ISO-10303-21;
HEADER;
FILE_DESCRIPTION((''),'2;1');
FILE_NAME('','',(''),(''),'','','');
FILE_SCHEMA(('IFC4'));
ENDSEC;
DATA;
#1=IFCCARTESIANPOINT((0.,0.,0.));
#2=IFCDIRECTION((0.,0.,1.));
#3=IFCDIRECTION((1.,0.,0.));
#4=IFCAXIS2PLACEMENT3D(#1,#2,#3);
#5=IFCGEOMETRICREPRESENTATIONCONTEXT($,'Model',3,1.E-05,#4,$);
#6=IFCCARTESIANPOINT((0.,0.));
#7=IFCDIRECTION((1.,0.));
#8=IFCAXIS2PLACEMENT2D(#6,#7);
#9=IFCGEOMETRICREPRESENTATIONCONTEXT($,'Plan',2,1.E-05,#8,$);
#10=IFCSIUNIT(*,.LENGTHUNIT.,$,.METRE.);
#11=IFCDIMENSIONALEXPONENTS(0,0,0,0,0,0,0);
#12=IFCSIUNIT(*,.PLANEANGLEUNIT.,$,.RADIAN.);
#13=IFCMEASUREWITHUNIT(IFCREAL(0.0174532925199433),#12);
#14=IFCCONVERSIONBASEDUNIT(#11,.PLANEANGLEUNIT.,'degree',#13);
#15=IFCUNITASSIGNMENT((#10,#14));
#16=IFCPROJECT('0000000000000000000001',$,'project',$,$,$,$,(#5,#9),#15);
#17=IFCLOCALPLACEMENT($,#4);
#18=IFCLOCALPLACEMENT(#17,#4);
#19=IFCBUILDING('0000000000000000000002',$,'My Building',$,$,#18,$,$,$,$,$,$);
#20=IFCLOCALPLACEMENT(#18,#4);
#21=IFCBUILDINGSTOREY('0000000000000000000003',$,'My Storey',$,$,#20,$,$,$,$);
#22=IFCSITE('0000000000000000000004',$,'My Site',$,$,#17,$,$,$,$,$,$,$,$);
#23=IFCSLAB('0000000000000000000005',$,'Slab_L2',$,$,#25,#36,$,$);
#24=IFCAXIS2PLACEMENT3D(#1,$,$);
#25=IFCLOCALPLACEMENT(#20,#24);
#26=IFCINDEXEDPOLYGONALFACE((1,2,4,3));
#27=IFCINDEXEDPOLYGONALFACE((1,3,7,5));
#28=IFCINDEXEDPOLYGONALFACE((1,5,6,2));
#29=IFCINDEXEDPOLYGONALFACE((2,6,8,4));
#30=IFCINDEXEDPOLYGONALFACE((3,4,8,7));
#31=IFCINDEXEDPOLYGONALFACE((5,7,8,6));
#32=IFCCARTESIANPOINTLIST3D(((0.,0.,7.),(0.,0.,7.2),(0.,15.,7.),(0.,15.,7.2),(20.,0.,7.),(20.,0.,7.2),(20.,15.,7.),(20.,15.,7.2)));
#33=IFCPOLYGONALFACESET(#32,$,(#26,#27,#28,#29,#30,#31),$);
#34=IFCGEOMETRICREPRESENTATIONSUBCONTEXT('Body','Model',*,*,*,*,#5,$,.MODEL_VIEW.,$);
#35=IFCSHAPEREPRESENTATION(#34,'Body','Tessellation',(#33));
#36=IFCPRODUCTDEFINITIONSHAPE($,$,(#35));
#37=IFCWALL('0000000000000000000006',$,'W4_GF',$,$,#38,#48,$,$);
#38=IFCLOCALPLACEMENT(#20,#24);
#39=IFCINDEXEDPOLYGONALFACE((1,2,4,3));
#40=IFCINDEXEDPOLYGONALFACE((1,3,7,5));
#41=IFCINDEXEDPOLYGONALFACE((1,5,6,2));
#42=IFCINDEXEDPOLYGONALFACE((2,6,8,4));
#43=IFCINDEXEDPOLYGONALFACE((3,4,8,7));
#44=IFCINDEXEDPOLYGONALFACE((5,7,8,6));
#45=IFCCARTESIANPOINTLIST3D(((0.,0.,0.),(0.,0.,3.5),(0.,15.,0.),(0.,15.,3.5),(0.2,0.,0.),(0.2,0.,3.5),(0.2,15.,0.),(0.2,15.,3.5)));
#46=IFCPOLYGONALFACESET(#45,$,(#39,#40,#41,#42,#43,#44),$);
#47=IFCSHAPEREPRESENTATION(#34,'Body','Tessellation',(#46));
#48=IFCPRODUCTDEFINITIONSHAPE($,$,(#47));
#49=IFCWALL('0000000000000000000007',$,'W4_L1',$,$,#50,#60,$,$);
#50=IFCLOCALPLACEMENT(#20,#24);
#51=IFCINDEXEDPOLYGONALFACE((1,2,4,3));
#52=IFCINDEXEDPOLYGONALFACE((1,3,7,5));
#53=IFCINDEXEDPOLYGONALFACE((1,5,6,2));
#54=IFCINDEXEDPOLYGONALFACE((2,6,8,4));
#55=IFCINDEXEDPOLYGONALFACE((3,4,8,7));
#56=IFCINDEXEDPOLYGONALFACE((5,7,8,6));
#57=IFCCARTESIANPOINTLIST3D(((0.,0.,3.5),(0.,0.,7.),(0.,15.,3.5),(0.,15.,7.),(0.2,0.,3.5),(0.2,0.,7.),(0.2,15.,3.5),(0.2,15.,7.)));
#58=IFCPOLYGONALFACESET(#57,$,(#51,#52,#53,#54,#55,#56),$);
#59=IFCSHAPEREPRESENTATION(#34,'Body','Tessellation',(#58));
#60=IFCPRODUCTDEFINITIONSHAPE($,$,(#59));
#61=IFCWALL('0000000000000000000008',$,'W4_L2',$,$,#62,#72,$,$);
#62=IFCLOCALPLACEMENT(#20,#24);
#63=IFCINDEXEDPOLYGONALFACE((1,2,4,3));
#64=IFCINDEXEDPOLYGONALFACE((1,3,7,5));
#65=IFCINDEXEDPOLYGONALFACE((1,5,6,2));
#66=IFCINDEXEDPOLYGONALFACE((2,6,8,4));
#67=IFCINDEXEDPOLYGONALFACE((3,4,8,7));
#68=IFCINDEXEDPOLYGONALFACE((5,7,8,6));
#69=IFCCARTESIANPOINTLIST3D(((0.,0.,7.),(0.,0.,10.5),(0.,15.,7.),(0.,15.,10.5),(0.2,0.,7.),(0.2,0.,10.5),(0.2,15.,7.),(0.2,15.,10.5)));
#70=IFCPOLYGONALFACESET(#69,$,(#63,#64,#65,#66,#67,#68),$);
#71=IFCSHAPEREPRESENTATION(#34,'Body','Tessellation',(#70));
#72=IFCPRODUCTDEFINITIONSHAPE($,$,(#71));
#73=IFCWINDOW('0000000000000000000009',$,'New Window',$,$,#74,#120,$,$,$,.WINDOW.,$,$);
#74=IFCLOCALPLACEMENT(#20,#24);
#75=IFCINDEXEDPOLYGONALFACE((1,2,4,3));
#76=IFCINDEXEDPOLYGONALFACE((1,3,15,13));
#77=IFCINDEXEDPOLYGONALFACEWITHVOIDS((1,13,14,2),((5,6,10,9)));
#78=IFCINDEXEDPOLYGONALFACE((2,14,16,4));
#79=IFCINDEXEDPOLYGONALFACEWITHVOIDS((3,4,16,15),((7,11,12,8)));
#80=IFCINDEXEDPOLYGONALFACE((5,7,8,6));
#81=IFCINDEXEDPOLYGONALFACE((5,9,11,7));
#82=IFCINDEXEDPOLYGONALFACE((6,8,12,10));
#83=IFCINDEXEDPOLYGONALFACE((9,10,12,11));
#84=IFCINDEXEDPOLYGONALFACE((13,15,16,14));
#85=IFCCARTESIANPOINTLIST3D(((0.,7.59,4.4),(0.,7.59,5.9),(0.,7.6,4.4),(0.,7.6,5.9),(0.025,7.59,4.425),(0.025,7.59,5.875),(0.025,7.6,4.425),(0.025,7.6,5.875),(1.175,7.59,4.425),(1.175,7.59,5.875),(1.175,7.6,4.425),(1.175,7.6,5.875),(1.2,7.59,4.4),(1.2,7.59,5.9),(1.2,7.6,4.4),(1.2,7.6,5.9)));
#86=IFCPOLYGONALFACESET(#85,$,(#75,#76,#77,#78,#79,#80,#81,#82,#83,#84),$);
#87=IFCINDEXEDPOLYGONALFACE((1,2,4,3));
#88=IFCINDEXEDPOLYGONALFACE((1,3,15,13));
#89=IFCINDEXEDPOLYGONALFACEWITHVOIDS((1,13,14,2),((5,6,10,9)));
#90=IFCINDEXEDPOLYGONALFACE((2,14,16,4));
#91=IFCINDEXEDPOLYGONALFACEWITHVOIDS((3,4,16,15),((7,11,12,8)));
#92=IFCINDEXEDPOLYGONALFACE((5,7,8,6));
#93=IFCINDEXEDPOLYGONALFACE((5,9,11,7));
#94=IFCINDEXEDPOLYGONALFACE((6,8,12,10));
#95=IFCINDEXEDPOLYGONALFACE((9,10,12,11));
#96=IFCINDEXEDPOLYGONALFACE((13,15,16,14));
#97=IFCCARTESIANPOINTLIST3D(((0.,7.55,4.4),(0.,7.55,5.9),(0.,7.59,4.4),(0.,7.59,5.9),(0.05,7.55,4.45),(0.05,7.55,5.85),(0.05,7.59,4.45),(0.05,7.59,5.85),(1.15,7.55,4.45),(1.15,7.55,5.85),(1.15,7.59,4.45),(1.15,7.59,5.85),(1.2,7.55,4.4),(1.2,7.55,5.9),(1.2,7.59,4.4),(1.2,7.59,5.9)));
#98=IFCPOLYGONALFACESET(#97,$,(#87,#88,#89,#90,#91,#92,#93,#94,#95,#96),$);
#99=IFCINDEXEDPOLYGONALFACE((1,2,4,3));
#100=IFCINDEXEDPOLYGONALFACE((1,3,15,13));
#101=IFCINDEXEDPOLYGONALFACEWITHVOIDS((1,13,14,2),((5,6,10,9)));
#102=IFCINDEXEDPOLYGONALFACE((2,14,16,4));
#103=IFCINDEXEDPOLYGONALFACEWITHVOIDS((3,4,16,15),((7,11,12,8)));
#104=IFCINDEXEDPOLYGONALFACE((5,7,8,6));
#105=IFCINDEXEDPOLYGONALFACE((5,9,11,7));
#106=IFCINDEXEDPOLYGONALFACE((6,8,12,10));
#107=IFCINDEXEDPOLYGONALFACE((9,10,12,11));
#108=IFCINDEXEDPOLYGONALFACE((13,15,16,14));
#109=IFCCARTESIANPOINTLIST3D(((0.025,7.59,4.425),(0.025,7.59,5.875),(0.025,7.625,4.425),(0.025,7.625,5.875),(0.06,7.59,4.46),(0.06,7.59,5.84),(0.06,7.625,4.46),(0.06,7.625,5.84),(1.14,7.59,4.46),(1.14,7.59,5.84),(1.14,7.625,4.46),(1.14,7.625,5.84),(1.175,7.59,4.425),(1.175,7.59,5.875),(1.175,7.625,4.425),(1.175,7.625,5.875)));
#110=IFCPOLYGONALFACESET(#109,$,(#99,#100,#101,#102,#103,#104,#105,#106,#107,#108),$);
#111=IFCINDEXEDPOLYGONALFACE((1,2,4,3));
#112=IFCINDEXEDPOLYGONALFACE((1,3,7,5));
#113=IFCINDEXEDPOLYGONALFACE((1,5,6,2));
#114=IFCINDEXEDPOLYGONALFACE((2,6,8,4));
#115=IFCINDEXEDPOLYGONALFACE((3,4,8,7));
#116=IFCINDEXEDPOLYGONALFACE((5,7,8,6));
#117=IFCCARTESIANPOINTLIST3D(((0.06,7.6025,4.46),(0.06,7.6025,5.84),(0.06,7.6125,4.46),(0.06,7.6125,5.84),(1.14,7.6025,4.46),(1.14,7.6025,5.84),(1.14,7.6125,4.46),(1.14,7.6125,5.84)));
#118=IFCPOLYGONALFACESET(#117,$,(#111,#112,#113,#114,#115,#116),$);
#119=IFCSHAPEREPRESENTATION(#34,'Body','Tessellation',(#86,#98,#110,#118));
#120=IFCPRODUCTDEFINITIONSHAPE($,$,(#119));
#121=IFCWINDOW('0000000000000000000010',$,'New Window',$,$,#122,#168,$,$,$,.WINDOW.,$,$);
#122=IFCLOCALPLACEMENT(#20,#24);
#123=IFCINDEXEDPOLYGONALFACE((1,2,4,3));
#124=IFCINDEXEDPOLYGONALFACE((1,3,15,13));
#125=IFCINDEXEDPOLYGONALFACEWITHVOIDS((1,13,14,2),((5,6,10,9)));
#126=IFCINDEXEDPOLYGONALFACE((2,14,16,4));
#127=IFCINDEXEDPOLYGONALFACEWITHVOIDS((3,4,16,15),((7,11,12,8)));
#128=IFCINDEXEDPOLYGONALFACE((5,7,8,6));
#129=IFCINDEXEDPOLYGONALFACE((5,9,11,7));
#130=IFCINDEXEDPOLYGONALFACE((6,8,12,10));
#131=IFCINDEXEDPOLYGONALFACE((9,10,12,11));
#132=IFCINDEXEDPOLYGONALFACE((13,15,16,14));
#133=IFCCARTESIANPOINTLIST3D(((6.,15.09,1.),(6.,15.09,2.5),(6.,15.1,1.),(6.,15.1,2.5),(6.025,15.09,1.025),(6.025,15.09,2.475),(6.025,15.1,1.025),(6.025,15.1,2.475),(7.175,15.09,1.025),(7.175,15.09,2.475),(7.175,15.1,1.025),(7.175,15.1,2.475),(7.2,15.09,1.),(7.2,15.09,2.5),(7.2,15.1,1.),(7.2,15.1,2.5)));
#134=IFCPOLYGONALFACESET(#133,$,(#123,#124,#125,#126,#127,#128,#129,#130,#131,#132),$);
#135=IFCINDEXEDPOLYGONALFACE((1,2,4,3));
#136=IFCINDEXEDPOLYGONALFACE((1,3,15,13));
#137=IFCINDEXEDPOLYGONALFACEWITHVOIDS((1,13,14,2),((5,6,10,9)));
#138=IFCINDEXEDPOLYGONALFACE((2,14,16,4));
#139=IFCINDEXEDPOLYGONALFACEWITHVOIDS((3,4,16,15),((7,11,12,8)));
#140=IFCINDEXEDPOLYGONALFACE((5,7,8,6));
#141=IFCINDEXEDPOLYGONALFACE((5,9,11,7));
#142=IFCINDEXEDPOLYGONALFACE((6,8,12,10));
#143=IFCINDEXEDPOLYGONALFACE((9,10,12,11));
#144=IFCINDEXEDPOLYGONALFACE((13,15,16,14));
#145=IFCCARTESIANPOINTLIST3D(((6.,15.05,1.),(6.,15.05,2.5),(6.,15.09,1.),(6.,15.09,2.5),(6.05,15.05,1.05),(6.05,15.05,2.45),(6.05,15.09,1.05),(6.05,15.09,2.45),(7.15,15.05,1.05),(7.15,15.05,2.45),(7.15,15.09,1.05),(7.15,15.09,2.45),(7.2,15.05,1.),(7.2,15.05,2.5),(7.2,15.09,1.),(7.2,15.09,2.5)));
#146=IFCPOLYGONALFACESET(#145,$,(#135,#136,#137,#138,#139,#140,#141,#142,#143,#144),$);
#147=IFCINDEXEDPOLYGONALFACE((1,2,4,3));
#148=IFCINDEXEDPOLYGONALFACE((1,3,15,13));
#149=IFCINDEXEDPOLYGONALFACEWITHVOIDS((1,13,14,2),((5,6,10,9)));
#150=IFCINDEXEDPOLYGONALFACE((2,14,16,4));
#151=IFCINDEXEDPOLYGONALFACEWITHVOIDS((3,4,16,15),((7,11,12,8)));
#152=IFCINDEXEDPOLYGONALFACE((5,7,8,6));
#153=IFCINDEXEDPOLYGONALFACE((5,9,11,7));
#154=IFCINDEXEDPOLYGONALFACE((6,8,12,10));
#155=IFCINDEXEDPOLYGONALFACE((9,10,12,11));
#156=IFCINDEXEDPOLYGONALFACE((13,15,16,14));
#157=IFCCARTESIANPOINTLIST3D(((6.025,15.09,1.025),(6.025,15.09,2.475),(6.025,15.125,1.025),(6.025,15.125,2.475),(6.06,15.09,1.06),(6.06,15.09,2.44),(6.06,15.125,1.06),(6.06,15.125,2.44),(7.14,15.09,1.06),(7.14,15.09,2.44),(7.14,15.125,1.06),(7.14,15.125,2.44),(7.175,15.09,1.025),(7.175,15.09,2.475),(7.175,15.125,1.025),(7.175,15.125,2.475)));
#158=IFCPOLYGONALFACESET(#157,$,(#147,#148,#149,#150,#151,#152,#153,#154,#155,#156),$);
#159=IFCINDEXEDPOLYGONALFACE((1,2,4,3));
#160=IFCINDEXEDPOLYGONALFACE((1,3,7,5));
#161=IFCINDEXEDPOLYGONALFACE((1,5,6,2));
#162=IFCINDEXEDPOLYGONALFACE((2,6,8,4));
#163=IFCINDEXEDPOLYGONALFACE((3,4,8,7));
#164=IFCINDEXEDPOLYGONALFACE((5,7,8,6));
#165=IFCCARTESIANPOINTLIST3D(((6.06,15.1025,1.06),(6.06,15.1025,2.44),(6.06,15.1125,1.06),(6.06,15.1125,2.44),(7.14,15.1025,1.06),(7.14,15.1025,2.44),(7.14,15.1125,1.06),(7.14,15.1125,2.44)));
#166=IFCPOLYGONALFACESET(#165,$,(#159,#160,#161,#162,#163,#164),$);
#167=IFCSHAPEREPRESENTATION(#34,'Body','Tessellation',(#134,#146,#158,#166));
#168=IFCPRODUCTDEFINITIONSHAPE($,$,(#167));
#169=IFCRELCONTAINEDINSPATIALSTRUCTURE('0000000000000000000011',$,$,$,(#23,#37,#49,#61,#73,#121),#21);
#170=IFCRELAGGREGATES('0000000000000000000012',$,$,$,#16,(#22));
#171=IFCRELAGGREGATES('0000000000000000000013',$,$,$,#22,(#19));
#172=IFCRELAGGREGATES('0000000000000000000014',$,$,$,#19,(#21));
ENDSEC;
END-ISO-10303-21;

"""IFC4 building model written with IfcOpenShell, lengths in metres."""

from ifc_helpers import new_model, entity, si_unit, converted_unit, frame, origin_with_axes, origin_2d_with_axis, place, context, subcontext, project, spatial, line, indexed_curve, outline, extrude, element, save


model = new_model("IFC4")

# Units and contexts
model_context = context("Model", 3, precision=1e-05, world=origin_with_axes())
plan_context = context("Plan", 2, precision=1e-05, world=origin_2d_with_axis())
body_context = subcontext(model_context, "Body", "Model", "MODEL_VIEW")
ifc_project = project(units=[si_unit("LENGTHUNIT", "METRE"), converted_unit("PLANEANGLEUNIT", "degree", entity("IfcReal", 0.0174532925199433), si_unit("PLANEANGLEUNIT", "RADIAN"), dimensions=[0, 0, 0, 0, 0, 0, 0])], contexts=[model_context, plan_context])

# Site, building, storey
site_placement = place(None, origin_with_axes())
site = spatial("IfcSite", under=ifc_project, at=site_placement, Name="My Site")
building_placement = place(site_placement, origin_with_axes())
building = spatial("IfcBuilding", under=site, at=building_placement, Name="My Building")
storey_placement = place(building_placement, origin_with_axes())
storey = spatial("IfcBuildingStorey", under=building, at=storey_placement, Name="My Storey")

# Slab
slab_placement = place(storey_placement, frame((0.0, 0.0, 7.0), z_axis=(0.0, 0.0, 1.0), x_axis=(1.0, 0.0, 0.0)))
element("IfcSlab", 1, at=slab_placement, inside=storey, Name="Slab_L2", context=body_context, shape_type="SweptSolid", body=[
    extrude(outline(indexed_curve([(0.0, 0.0), (20.0, 0.0), (20.0, 15.0), (0.0, 15.0), (0.0, 0.0)])), None, (0.0, 0.0, 1.0), 0.2),
])

# Walls
for number, where, z_axis, x_axis, name in (
    (2, (0.0, 15.0, 0.0), (0.0, 0.0, 1.0), (0.0, -1.0, 0.0), "W4_GF"),
    (3, (0.0, 15.0, 3.5), (0.0, 0.0, 1.0), (0.0, -1.0, 0.0), "W4_L1"),
    (4, (0.0, 15.0, 7.0), (0.0, 0.0, 1.0), (0.0, -1.0, 0.0), "W4_L2"),
):
    element("IfcWall", number, at=place(storey_placement, frame(where, z_axis=z_axis, x_axis=x_axis)), inside=storey, Name=name, context=body_context, shape_type="SweptSolid", body=[
        extrude(outline(indexed_curve([(0.0, 0.0), (0.0, 0.2), (15.0, 0.2), (15.0, 0.0), (0.0, 0.0)], self_intersect=False)), origin_with_axes(), (0.0, 0.0, 1.0), 3.5),
    ])

# Window
window_1_placement = place(storey_placement, frame((0.0, 7.5, 4.4), z_axis=(0.0, 0.0, 1.0), x_axis=(1.0, 0.0, 0.0)))
element("IfcWindow", 5, at=window_1_placement, inside=storey, Name="New Window", PredefinedType="WINDOW", context=body_context, shape_type="SweptSolid", body=[
    extrude(outline(indexed_curve([(0.0, 0.0), (1.2, 0.0), (1.2, 1.5), (0.0, 1.5)], segments=[line(1, 2, 3, 4, 1)]), holes=[indexed_curve([(0.025, 0.025), (1.175, 0.025), (1.175, 1.475), (0.025, 1.475)], segments=[line(1, 2, 3, 4, 1)])]), frame((0.0, 0.09, 0.0), z_axis=(0.0, -1.0, 0.0), x_axis=(1.0, 0.0, 0.0)), (0.0, 0.0, -1.0), 0.01),
    extrude(outline(indexed_curve([(0.0, 0.0), (1.2, 0.0), (1.2, 1.5), (0.0, 1.5)], segments=[line(1, 2, 3, 4, 1)]), holes=[indexed_curve([(0.05, 0.05), (1.15, 0.05), (1.15, 1.45), (0.05, 1.45)], segments=[line(1, 2, 3, 4, 1)])]), frame((0.0, 0.05, 0.0), z_axis=(0.0, -1.0, 0.0), x_axis=(1.0, 0.0, 0.0)), (0.0, 0.0, -1.0), 0.04),
    extrude(outline(indexed_curve([(0.0, 0.0), (1.15, 0.0), (1.15, 1.45), (0.0, 1.45)], segments=[line(1, 2, 3, 4, 1)]), holes=[indexed_curve([(0.035, 0.035), (1.115, 0.035), (1.115, 1.415), (0.035, 1.415)], segments=[line(1, 2, 3, 4, 1)])]), frame((0.025, 0.09, 0.025), z_axis=(0.0, -1.0, 0.0), x_axis=(1.0, 0.0, 0.0)), (0.0, 0.0, -1.0), 0.035),
    extrude(outline(indexed_curve([(0.035, 0.035), (1.115, 0.035), (1.115, 1.415), (0.035, 1.415)], segments=[line(1, 2, 3, 4, 1)])), frame((0.025, 0.1025, 0.025), z_axis=(0.0, -1.0, 0.0), x_axis=(1.0, 0.0, 0.0)), (0.0, 0.0, -1.0), 0.01),
])

# Window
window_2_placement = place(storey_placement, frame((6.0, 15.0, 1.0), z_axis=(0.0, 0.0, 1.0), x_axis=(1.0, 0.0, 0.0)))
element("IfcWindow", 6, at=window_2_placement, inside=storey, Name="New Window", PredefinedType="WINDOW", context=body_context, shape_type="SweptSolid", body=[
    extrude(outline(indexed_curve([(0.0, 0.0), (1.2, 0.0), (1.2, 1.5), (0.0, 1.5)], segments=[line(1, 2, 3, 4, 1)]), holes=[indexed_curve([(0.025, 0.025), (1.175, 0.025), (1.175, 1.475), (0.025, 1.475)], segments=[line(1, 2, 3, 4, 1)])]), frame((0.0, 0.09, 0.0), z_axis=(0.0, -1.0, 0.0), x_axis=(1.0, 0.0, 0.0)), (0.0, 0.0, -1.0), 0.01),
    extrude(outline(indexed_curve([(0.0, 0.0), (1.2, 0.0), (1.2, 1.5), (0.0, 1.5)], segments=[line(1, 2, 3, 4, 1)]), holes=[indexed_curve([(0.05, 0.05), (1.15, 0.05), (1.15, 1.45), (0.05, 1.45)], segments=[line(1, 2, 3, 4, 1)])]), frame((0.0, 0.05, 0.0), z_axis=(0.0, -1.0, 0.0), x_axis=(1.0, 0.0, 0.0)), (0.0, 0.0, -1.0), 0.04),
    extrude(outline(indexed_curve([(0.0, 0.0), (1.15, 0.0), (1.15, 1.45), (0.0, 1.45)], segments=[line(1, 2, 3, 4, 1)]), holes=[indexed_curve([(0.035, 0.035), (1.115, 0.035), (1.115, 1.415), (0.035, 1.415)], segments=[line(1, 2, 3, 4, 1)])]), frame((0.025, 0.09, 0.025), z_axis=(0.0, -1.0, 0.0), x_axis=(1.0, 0.0, 0.0)), (0.0, 0.0, -1.0), 0.035),
    extrude(outline(indexed_curve([(0.035, 0.035), (1.115, 0.035), (1.115, 1.415), (0.035, 1.415)], segments=[line(1, 2, 3, 4, 1)])), frame((0.025, 0.1025, 0.025), z_axis=(0.0, -1.0, 0.0), x_axis=(1.0, 0.0, 0.0)), (0.0, 0.0, -1.0), 0.01),
])

save(model, "model.ifc")
